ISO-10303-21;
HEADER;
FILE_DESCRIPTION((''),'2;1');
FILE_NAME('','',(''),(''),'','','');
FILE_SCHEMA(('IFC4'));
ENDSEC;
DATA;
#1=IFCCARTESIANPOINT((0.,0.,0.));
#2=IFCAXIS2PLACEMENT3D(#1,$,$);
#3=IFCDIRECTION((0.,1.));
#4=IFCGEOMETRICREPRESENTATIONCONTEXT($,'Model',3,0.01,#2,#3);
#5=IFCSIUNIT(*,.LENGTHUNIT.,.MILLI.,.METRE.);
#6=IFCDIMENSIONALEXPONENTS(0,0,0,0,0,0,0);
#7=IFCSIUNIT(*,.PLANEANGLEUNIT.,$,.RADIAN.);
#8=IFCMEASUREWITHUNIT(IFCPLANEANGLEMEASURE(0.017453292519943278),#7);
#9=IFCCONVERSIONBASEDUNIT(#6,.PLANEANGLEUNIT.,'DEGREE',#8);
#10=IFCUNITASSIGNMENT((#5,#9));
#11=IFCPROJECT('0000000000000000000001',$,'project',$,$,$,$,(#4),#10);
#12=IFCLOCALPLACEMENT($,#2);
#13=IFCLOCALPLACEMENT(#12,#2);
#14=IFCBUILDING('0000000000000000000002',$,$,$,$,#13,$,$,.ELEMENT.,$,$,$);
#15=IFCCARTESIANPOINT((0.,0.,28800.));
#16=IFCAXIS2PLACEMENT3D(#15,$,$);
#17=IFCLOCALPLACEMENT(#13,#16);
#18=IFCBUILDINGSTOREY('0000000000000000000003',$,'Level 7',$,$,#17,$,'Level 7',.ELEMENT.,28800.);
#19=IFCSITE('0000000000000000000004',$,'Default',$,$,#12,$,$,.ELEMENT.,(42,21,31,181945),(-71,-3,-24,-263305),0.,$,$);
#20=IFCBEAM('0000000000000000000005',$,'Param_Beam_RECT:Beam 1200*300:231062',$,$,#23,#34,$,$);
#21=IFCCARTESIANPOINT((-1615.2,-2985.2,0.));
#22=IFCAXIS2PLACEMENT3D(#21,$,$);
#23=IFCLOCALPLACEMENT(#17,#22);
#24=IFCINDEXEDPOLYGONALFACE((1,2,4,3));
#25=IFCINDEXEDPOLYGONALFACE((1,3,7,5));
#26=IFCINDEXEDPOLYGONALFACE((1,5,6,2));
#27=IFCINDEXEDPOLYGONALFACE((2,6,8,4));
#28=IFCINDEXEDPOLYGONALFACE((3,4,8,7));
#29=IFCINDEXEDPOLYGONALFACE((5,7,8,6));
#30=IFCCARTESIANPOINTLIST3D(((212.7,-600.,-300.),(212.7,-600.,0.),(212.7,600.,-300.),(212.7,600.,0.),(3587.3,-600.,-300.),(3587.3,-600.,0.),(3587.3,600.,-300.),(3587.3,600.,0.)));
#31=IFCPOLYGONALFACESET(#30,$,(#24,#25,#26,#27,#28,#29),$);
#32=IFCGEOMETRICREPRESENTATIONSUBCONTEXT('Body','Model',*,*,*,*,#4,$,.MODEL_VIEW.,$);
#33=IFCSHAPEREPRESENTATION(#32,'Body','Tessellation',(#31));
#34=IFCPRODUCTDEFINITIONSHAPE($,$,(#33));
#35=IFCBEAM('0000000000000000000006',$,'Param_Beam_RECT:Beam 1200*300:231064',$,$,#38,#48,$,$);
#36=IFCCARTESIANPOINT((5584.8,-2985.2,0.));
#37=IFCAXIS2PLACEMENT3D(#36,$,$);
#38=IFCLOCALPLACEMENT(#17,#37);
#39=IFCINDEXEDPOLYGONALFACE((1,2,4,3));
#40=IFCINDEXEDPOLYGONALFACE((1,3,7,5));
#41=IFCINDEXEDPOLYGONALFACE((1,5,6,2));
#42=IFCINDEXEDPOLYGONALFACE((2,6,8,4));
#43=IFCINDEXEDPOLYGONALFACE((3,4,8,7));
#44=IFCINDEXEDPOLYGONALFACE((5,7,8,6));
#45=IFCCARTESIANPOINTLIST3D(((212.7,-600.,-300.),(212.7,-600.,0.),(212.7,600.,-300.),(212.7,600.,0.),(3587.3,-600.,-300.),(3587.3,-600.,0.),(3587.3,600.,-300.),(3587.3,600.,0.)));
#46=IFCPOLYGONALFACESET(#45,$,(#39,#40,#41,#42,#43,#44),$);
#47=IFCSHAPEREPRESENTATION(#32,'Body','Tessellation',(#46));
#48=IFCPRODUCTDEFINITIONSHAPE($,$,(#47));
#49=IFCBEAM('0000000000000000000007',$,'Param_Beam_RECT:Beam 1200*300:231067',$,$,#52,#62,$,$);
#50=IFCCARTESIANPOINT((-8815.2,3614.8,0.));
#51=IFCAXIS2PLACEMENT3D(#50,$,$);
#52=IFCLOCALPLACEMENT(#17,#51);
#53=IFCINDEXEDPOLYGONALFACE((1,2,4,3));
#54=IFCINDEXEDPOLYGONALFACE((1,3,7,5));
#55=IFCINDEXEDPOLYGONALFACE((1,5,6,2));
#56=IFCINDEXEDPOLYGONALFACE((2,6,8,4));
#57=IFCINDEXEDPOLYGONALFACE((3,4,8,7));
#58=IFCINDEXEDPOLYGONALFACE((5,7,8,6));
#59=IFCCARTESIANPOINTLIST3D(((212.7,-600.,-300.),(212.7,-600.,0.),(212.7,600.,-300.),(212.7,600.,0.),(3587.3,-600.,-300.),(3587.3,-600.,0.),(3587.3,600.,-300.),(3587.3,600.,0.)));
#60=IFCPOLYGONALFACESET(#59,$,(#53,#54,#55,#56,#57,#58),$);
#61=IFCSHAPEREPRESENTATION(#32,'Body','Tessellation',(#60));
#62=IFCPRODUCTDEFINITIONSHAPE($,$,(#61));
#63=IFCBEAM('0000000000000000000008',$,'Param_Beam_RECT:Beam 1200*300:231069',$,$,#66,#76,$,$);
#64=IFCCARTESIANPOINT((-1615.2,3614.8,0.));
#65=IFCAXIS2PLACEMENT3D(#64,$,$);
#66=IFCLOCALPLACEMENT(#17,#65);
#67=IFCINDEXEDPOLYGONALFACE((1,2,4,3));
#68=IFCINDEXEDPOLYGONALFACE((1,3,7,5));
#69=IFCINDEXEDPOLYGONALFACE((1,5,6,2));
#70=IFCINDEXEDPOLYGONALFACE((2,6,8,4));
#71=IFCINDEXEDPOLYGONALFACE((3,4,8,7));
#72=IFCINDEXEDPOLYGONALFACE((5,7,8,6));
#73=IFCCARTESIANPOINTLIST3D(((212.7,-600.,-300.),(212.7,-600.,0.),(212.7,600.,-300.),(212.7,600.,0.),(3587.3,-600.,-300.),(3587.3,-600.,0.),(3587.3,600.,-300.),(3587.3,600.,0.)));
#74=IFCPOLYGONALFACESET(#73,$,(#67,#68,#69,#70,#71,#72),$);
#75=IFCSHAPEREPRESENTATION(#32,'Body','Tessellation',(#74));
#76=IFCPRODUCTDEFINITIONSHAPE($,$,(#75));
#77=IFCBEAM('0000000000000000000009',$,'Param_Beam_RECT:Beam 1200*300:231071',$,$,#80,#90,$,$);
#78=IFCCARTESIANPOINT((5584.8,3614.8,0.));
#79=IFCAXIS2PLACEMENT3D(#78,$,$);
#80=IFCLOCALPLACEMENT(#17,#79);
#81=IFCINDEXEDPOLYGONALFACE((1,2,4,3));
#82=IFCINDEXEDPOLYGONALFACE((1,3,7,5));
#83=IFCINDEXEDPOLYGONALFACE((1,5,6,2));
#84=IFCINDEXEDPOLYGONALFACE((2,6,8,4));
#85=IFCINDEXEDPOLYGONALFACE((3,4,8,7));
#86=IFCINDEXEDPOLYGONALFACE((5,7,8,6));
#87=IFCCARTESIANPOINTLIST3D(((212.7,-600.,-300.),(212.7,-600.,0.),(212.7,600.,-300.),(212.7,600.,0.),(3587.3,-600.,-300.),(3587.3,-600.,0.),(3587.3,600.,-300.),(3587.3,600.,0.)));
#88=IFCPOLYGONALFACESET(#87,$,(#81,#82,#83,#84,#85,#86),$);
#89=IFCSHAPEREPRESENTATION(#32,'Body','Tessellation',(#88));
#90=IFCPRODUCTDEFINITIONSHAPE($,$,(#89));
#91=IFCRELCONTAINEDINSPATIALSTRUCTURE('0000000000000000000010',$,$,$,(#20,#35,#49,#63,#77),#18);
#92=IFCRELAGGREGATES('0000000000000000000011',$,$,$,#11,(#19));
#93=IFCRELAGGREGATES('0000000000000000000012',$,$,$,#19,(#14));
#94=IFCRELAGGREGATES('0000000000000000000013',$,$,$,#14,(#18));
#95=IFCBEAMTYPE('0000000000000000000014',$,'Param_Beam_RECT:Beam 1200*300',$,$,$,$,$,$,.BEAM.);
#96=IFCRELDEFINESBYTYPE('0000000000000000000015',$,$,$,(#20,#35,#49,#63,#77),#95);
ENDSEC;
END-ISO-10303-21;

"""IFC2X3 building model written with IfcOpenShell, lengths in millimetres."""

from ifc_helpers import new_model, entity, si_unit, converted_unit, direction, frame, frame_2d, origin, place, context, subcontext, project, spatial, rectangle, extrude, type_object, element, save


model = new_model("IFC2X3")

# Units and contexts
model_context = context("Model", 3, precision=0.01, world=origin(), true_north=direction((0.0, 1.0)))
body_context = subcontext(model_context, "Body", "Model", "MODEL_VIEW")
ifc_project = project(units=[si_unit("LENGTHUNIT", "METRE", prefix="MILLI"), converted_unit("PLANEANGLEUNIT", "DEGREE", entity("IfcPlaneAngleMeasure", 0.017453292519943278), si_unit("PLANEANGLEUNIT", "RADIAN"), dimensions=[0, 0, 0, 0, 0, 0, 0])], contexts=[model_context])

# Site, building, storey
site_placement = place(None, origin())
site = spatial("IfcSite", under=ifc_project, at=site_placement, Name="Default", CompositionType="ELEMENT", RefLatitude=(42, 21, 31, 181945), RefLongitude=(-71, -3, -24, -263305), RefElevation=0.0)
building_placement = place(site_placement, origin())
building = spatial("IfcBuilding", under=site, at=building_placement, CompositionType="ELEMENT")
storey_placement = place(building_placement, frame((0.0, 0.0, 28800.0)))
storey = spatial("IfcBuildingStorey", under=building, at=storey_placement, Name="Level 7", LongName="Level 7", CompositionType="ELEMENT", Elevation=28800.0)

# Beams
beam_type_1 = type_object("IfcBeamType", Name="Param_Beam_RECT:Beam 1200*300", PredefinedType="BEAM")
beam_1_placement = place(storey_placement, frame((-1615.2, -2985.2, 0.0)))
element("IfcBeam", 1, at=beam_1_placement, inside=storey, type_object=beam_type_1, Name="Param_Beam_RECT:Beam 1200*300:231062", context=body_context, shape_type="SweptSolid", body=[
    extrude(rectangle(XDim=300.0, YDim=1200.0, at=frame_2d((0.0, 0.0), x_axis=(1.0, 0.0))), frame((212.7, 0.0, -150.0), z_axis=(1.0, 0.0, 0.0), x_axis=(0.0, 0.0, -1.0)), (0.0, 0.0, 1.0), 3374.6),
])
beam_2_placement = place(storey_placement, frame((5584.8, -2985.2, 0.0)))
element("IfcBeam", 2, at=beam_2_placement, inside=storey, type_object=beam_type_1, Name="Param_Beam_RECT:Beam 1200*300:231064", context=body_context, shape_type="SweptSolid", body=[
    extrude(rectangle(XDim=300.0, YDim=1200.0, at=frame_2d((0.0, 0.0), x_axis=(1.0, 0.0))), frame((212.7, 0.0, -150.0), z_axis=(1.0, 0.0, 0.0), x_axis=(0.0, 0.0, -1.0)), (0.0, 0.0, 1.0), 3374.6),
])
beam_3_placement = place(storey_placement, frame((-8815.2, 3614.8, 0.0)))
element("IfcBeam", 3, at=beam_3_placement, inside=storey, type_object=beam_type_1, Name="Param_Beam_RECT:Beam 1200*300:231067", context=body_context, shape_type="SweptSolid", body=[
    extrude(rectangle(XDim=300.0, YDim=1200.0, at=frame_2d((0.0, 0.0), x_axis=(1.0, 0.0))), frame((212.7, 0.0, -150.0), z_axis=(1.0, 0.0, 0.0), x_axis=(0.0, 0.0, -1.0)), (0.0, 0.0, 1.0), 3374.6),
])
beam_4_placement = place(storey_placement, frame((-1615.2, 3614.8, 0.0)))
element("IfcBeam", 4, at=beam_4_placement, inside=storey, type_object=beam_type_1, Name="Param_Beam_RECT:Beam 1200*300:231069", context=body_context, shape_type="SweptSolid", body=[
    extrude(rectangle(XDim=300.0, YDim=1200.0, at=frame_2d((0.0, 0.0), x_axis=(1.0, 0.0))), frame((212.7, 0.0, -150.0), z_axis=(1.0, 0.0, 0.0), x_axis=(0.0, 0.0, -1.0)), (0.0, 0.0, 1.0), 3374.6),
])
beam_5_placement = place(storey_placement, frame((5584.8, 3614.8, 0.0)))
element("IfcBeam", 5, at=beam_5_placement, inside=storey, type_object=beam_type_1, Name="Param_Beam_RECT:Beam 1200*300:231071", context=body_context, shape_type="SweptSolid", body=[
    extrude(rectangle(XDim=300.0, YDim=1200.0, at=frame_2d((0.0, 0.0), x_axis=(1.0, 0.0))), frame((212.7, 0.0, -150.0), z_axis=(1.0, 0.0, 0.0), x_axis=(0.0, 0.0, -1.0)), (0.0, 0.0, 1.0), 3374.6),
])

save(model, "model.ifc")
